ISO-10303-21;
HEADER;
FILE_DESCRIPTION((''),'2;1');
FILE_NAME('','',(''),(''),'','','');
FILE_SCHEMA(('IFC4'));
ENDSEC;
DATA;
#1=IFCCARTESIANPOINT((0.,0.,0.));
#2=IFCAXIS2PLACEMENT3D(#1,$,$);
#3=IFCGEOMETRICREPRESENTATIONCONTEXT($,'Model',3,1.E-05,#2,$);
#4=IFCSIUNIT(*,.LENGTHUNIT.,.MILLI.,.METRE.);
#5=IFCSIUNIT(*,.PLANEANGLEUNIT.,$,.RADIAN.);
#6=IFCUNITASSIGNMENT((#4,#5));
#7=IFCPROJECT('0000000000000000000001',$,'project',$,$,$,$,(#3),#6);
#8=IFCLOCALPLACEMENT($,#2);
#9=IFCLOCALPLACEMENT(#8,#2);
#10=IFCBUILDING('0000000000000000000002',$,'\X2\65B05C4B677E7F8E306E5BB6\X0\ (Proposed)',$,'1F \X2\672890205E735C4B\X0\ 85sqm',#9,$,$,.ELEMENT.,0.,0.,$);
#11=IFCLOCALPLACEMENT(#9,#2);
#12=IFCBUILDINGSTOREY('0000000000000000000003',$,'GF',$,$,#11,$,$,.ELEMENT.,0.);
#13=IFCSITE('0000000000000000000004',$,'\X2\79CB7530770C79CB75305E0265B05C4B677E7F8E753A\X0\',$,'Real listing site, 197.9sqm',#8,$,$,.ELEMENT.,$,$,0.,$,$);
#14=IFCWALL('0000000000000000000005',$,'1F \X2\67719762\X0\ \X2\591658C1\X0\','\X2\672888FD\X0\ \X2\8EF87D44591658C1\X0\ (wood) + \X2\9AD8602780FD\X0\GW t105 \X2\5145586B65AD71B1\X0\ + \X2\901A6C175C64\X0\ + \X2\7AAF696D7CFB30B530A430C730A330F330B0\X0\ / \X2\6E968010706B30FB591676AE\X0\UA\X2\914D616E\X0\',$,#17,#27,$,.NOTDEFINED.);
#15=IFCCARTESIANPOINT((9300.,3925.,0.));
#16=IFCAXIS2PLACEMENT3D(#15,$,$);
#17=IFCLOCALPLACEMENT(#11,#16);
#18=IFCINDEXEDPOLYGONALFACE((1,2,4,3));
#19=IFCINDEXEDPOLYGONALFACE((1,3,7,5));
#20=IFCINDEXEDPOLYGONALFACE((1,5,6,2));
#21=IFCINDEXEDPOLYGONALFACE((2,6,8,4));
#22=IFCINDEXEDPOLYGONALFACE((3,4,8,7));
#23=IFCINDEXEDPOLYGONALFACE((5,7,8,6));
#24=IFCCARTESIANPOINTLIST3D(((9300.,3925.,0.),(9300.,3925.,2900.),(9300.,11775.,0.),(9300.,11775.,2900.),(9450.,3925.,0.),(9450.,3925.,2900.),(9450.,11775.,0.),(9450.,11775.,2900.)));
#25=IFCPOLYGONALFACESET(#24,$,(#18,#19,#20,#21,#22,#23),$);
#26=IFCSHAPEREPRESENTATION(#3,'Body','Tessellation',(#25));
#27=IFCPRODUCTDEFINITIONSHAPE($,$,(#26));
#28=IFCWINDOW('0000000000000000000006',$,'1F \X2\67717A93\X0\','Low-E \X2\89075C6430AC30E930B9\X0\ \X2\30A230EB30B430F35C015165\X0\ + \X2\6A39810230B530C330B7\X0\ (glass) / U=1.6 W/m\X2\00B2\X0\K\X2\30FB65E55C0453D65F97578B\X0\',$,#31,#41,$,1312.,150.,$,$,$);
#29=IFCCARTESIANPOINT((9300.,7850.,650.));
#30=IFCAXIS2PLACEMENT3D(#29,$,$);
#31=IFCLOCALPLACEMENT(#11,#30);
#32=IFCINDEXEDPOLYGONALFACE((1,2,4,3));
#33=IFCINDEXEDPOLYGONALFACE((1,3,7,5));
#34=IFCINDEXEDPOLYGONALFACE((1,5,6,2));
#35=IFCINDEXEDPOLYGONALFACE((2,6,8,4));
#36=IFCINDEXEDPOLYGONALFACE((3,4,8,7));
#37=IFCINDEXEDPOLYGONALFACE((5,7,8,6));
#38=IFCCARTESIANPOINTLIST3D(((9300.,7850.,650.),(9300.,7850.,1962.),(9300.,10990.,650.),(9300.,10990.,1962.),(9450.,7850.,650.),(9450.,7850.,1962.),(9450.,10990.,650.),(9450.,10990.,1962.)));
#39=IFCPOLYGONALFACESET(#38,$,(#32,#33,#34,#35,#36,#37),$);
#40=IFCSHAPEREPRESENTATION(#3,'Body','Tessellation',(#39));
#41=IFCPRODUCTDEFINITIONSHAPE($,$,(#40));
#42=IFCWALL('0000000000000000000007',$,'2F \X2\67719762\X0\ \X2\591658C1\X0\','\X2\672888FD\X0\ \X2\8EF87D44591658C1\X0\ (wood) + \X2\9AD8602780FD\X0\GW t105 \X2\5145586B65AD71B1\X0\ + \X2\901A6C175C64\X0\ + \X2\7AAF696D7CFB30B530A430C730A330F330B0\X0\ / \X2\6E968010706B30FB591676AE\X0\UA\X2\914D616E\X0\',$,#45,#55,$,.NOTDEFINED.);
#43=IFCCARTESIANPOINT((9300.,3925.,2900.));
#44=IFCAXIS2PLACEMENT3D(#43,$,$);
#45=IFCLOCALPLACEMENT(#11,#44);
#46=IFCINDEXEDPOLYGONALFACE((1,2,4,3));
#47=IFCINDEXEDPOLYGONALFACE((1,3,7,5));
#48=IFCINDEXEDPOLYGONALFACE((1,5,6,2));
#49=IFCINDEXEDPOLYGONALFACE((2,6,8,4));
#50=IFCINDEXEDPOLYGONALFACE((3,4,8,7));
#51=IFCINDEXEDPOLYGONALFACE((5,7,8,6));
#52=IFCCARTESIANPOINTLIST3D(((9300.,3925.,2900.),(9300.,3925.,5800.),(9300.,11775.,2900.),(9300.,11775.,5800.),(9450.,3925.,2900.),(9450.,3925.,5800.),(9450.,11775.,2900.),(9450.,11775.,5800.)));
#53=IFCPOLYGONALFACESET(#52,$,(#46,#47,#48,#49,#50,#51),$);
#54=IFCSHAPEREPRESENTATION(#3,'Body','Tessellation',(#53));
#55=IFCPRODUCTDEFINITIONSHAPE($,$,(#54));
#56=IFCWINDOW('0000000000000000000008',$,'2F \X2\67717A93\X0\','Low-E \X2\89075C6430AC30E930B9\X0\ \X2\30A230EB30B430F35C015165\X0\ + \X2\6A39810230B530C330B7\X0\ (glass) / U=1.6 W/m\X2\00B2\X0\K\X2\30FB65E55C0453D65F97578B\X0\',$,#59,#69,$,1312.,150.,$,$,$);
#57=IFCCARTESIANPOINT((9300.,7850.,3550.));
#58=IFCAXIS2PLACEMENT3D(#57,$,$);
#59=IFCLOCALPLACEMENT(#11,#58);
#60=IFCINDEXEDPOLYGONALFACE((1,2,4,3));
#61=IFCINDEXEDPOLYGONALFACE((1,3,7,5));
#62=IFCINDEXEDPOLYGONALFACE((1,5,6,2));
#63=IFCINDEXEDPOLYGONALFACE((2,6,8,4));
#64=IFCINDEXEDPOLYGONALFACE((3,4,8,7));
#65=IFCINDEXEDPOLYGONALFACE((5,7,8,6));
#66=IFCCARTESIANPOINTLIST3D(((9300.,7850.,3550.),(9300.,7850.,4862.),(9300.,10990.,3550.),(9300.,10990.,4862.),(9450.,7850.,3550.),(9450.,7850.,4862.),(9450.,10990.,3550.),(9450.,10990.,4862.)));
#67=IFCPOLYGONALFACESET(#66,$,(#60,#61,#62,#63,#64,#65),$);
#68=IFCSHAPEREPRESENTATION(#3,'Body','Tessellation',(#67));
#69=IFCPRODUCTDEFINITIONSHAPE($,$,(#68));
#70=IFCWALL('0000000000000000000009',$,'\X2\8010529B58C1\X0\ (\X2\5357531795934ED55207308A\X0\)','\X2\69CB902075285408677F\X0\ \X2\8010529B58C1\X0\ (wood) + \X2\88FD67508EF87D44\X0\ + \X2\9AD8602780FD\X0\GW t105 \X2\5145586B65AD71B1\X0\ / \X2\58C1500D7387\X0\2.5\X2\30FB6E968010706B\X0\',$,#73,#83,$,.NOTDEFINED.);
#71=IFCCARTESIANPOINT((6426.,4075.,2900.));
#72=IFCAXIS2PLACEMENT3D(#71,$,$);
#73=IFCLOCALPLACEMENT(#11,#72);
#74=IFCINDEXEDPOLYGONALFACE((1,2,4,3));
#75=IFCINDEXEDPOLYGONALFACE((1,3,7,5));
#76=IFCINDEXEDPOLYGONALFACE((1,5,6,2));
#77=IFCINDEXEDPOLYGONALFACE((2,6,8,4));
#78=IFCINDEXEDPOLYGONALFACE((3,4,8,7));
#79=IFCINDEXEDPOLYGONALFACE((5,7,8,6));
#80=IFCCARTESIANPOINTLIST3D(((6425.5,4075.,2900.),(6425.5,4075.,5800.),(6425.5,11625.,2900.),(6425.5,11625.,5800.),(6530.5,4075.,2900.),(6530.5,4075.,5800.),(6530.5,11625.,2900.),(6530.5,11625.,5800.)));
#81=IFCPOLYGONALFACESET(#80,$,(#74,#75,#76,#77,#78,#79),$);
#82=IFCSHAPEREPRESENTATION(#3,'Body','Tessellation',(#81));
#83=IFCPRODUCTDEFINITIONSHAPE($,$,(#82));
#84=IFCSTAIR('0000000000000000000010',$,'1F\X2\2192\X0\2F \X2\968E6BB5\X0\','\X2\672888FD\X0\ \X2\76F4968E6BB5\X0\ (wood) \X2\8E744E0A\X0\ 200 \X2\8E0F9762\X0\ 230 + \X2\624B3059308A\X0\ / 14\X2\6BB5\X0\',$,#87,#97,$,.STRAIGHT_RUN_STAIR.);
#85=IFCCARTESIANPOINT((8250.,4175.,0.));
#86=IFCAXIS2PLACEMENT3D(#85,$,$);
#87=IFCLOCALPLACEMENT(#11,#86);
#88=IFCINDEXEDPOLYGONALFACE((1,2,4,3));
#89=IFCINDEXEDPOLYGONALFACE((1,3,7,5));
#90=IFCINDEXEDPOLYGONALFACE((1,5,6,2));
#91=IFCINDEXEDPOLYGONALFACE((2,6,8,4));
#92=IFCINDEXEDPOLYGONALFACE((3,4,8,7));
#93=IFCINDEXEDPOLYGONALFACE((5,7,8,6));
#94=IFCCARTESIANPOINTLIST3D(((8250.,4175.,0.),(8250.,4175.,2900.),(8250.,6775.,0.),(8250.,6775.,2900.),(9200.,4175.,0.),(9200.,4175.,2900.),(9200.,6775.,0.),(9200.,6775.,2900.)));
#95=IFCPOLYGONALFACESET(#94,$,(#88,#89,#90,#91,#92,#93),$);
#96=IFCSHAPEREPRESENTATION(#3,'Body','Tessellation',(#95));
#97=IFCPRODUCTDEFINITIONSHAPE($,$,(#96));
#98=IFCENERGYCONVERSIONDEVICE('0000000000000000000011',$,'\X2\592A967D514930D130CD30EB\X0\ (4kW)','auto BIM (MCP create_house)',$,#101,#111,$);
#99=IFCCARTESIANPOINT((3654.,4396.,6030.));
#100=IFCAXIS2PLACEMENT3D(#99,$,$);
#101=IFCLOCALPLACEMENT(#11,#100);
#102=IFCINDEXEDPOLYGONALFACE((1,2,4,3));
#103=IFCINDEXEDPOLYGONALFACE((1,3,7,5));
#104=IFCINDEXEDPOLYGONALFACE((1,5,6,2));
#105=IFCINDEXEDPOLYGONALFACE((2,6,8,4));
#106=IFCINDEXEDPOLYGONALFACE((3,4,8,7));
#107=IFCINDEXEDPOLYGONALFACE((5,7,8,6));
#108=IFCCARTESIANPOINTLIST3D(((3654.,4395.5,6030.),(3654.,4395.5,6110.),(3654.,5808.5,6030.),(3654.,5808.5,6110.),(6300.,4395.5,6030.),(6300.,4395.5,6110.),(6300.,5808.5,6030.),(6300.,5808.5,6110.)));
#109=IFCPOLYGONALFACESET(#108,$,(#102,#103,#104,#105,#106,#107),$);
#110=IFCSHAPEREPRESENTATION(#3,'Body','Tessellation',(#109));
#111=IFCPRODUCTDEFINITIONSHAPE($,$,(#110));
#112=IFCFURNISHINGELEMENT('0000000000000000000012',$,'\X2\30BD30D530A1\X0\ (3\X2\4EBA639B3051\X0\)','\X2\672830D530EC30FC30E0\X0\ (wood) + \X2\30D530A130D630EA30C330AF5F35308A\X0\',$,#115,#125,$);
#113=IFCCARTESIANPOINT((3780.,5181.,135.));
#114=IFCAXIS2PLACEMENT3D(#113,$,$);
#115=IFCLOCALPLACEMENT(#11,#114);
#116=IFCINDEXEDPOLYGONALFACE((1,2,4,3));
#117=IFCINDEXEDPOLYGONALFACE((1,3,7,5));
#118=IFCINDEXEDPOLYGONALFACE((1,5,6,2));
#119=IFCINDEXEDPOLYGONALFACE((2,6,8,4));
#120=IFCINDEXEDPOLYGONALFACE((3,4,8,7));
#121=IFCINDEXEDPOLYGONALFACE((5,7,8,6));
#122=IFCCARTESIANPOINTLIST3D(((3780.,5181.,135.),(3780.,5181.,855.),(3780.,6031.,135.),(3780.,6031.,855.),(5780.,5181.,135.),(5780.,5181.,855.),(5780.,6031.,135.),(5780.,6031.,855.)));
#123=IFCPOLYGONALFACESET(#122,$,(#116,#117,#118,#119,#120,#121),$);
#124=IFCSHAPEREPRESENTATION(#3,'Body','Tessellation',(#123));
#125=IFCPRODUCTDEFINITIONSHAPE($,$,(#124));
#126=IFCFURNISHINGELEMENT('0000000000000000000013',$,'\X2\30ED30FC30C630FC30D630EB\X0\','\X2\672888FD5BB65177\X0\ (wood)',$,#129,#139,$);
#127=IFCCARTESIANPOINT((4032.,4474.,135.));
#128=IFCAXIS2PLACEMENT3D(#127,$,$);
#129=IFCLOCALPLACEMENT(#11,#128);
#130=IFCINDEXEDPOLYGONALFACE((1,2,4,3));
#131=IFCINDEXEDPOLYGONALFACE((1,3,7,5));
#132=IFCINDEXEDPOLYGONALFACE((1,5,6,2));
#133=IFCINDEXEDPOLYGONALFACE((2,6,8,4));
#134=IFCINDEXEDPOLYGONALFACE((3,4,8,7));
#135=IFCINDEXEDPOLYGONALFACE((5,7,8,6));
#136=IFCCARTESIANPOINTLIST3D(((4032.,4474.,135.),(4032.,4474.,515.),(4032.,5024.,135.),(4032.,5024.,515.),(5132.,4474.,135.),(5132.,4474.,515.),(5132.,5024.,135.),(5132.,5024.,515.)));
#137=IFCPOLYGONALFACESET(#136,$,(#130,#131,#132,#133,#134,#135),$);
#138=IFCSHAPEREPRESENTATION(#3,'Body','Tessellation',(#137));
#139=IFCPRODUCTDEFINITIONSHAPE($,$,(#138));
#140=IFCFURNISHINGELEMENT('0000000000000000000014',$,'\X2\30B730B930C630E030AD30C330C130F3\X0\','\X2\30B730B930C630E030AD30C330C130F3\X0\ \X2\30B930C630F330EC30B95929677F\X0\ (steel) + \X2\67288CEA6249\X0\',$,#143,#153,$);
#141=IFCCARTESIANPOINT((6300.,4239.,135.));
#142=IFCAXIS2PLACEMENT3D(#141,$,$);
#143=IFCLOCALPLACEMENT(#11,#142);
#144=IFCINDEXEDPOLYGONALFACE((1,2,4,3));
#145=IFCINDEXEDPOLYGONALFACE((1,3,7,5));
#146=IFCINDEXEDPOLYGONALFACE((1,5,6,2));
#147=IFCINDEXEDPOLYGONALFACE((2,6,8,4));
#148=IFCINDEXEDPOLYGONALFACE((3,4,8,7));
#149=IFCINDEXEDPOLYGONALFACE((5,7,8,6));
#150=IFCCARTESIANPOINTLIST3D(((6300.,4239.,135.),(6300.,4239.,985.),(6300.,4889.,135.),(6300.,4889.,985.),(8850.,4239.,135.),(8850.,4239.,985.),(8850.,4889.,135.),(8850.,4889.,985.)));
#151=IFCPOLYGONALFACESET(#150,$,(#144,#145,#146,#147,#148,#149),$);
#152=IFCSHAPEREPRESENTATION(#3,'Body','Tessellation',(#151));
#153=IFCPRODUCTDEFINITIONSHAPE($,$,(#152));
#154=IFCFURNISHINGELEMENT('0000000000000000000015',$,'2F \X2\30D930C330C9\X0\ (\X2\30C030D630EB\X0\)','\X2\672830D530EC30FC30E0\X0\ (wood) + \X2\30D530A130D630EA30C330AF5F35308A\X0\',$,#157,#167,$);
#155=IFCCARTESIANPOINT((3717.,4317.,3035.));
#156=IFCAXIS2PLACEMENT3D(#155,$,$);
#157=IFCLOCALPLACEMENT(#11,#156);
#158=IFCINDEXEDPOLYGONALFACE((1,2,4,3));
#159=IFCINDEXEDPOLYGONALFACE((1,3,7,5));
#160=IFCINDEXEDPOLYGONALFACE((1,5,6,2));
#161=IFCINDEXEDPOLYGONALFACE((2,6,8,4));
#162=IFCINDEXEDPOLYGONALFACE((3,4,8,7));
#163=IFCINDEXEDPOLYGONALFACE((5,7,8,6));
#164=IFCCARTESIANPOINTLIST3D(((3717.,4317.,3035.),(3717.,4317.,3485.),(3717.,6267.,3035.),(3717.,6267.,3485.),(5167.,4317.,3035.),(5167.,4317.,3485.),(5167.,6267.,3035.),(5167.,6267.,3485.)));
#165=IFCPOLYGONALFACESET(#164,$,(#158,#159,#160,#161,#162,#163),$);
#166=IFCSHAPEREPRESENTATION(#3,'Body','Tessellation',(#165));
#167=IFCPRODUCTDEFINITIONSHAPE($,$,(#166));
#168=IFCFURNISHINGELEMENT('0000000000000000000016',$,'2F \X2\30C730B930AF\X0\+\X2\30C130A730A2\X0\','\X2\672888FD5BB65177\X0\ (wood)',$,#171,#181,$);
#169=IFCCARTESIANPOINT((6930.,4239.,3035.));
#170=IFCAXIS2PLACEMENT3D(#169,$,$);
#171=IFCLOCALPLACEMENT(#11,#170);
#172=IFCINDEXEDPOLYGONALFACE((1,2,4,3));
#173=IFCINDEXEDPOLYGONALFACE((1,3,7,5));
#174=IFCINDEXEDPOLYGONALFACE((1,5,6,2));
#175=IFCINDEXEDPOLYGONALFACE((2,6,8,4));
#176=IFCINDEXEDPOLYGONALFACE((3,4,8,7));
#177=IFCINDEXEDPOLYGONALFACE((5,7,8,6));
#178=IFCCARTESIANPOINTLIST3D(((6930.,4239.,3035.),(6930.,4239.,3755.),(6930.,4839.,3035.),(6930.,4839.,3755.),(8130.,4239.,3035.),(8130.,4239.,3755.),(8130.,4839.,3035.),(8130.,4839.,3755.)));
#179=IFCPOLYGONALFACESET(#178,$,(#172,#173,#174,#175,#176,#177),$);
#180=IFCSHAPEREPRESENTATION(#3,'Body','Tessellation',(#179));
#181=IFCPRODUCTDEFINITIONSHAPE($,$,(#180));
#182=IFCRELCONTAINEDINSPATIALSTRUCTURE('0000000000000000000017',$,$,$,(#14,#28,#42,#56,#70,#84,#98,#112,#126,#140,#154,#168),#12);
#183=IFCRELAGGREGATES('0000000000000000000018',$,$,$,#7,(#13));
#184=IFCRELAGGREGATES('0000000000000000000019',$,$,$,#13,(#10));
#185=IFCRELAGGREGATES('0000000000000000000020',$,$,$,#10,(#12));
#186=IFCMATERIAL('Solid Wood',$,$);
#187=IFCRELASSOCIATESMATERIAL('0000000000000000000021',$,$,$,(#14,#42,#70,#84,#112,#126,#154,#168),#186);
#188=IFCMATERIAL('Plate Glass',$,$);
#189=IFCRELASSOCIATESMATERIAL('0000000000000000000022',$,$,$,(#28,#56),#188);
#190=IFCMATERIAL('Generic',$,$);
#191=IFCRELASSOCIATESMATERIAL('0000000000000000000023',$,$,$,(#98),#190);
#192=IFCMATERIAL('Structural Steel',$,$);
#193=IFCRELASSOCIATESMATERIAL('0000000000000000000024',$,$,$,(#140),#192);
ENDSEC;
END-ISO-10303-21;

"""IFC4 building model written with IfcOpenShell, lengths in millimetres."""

from ifc_helpers import new_model, si_unit, frame, frame_2d, origin, place, context, project, spatial, rectangle, extrude, material, element, fill, save


model = new_model("IFC4")

# Units and contexts
model_context = context("Model", 3, precision=1e-05, world=origin())
ifc_project = project(units=[si_unit("LENGTHUNIT", "METRE", prefix="MILLI"), si_unit("PLANEANGLEUNIT", "RADIAN")], contexts=[model_context])

# Site, building, storey
site_placement = place(None, origin())
site = spatial("IfcSite", under=ifc_project, at=site_placement, Name="秋田県秋田市新屋松美町", ObjectType="Real listing site, 197.9sqm", CompositionType="ELEMENT", RefElevation=0.0)
building_placement = place(site_placement, origin())
building = spatial("IfcBuilding", under=site, at=building_placement, Name="新屋松美の家 (Proposed)", ObjectType="1F 木造平屋 85sqm", CompositionType="ELEMENT", ElevationOfRefHeight=0.0, ElevationOfTerrain=0.0)
storey_placement = place(building_placement, origin())
storey = spatial("IfcBuildingStorey", under=building, at=storey_placement, Name="GF", CompositionType="ELEMENT", Elevation=0.0)

# Wall, opening, window
ifc_material_1 = material(Name="Solid Wood")
wall_1_placement = place(storey_placement, frame((9300.0, 3925.0, 0.0)))
wall_1 = element("IfcWall", 1, at=wall_1_placement, inside=storey, material=ifc_material_1, Name="1F 東面 外壁", Description="木製 軸組外壁 (wood) + 高性能GW t105 充填断熱 + 通気層 + 窯業系サイディング / 準耐火・外皮UA配慮", PredefinedType="NOTDEFINED", context=model_context, shape_type="SweptSolid", body=[
    extrude(rectangle(XDim=150.0, YDim=7850.0, at=frame_2d((75.0, 3925.0))), frame((9300.0, 3925.0, 0.0)), (0.0, 0.0, 1.0), 2900.0),
])
opening_1_placement = place(storey_placement, frame((9300.0, 7850.0, 650.0)))
opening_1 = element("IfcOpeningElement", 2, at=opening_1_placement, cuts=wall_1, PredefinedType="NOTDEFINED", context=model_context, shape_type="SweptSolid", body=[
    extrude(rectangle(XDim=150.0, YDim=3140.0, at=frame_2d((75.0, 1570.0))), frame((9300.0, 7850.0, 650.0)), (0.0, 0.0, 1.0), 1312.0),
])
ifc_material_2 = material(Name="Plate Glass")
window_1_placement = place(storey_placement, frame((9300.0, 7850.0, 650.0)))
window_1 = element("IfcWindow", 3, at=window_1_placement, inside=storey, material=ifc_material_2, Name="1F 東窓", Description="Low-E 複層ガラス アルゴン封入 + 樹脂サッシ (glass) / U=1.6 W/m²K・日射取得型", OverallHeight=1312.0, OverallWidth=150.0, context=model_context, shape_type="SweptSolid", body=[
    extrude(rectangle(XDim=150.0, YDim=3140.0, at=frame_2d((75.0, 1570.0))), frame((9300.0, 7850.0, 650.0)), (0.0, 0.0, 1.0), 1312.0),
])
fill(opening_1, window_1)

# Wall, opening, window
wall_2_placement = place(storey_placement, frame((9300.0, 3925.0, 2900.0)))
wall_2 = element("IfcWall", 4, at=wall_2_placement, inside=storey, material=ifc_material_1, Name="2F 東面 外壁", Description="木製 軸組外壁 (wood) + 高性能GW t105 充填断熱 + 通気層 + 窯業系サイディング / 準耐火・外皮UA配慮", PredefinedType="NOTDEFINED", context=model_context, shape_type="SweptSolid", body=[
    extrude(rectangle(XDim=150.0, YDim=7850.0, at=frame_2d((75.0, 3925.0))), frame((9300.0, 3925.0, 2900.0)), (0.0, 0.0, 1.0), 2900.0),
])
opening_2_placement = place(storey_placement, frame((9300.0, 7850.0, 3550.0)))
opening_2 = element("IfcOpeningElement", 5, at=opening_2_placement, cuts=wall_2, PredefinedType="NOTDEFINED", context=model_context, shape_type="SweptSolid", body=[
    extrude(rectangle(XDim=150.0, YDim=3140.0, at=frame_2d((75.0, 1570.0))), frame((9300.0, 7850.0, 3550.0)), (0.0, 0.0, 1.0), 1312.0),
])
window_2_placement = place(storey_placement, frame((9300.0, 7850.0, 3550.0)))
window_2 = element("IfcWindow", 6, at=window_2_placement, inside=storey, material=ifc_material_2, Name="2F 東窓", Description="Low-E 複層ガラス アルゴン封入 + 樹脂サッシ (glass) / U=1.6 W/m²K・日射取得型", OverallHeight=1312.0, OverallWidth=150.0, context=model_context, shape_type="SweptSolid", body=[
    extrude(rectangle(XDim=150.0, YDim=3140.0, at=frame_2d((75.0, 1570.0))), frame((9300.0, 7850.0, 3550.0)), (0.0, 0.0, 1.0), 1312.0),
])
fill(opening_2, window_2)

# Wall
wall_3_placement = place(storey_placement, frame((6426.0, 4075.0, 2900.0)))
element("IfcWall", 7, at=wall_3_placement, inside=storey, material=ifc_material_1, Name="耐力壁 (南北間仕切り)", Description="構造用合板 耐力壁 (wood) + 製材軸組 + 高性能GW t105 充填断熱 / 壁倍率2.5・準耐火", PredefinedType="NOTDEFINED", context=model_context, shape_type="SweptSolid", body=[
    extrude(rectangle(XDim=105.0, YDim=7550.0, at=frame_2d((52.0, 3775.0))), frame((6426.0, 4075.0, 2900.0)), (0.0, 0.0, 1.0), 2900.0),
])

# Stair
stair_placement = place(storey_placement, frame((8250.0, 4175.0, 0.0)))
element("IfcStair", 8, at=stair_placement, inside=storey, material=ifc_material_1, Name="1F→2F 階段", Description="木製 直階段 (wood) 蹴上 200 踏面 230 + 手すり / 14段", PredefinedType="STRAIGHT_RUN_STAIR", context=model_context, shape_type="SweptSolid", body=[
    extrude(rectangle(XDim=950.0, YDim=2600.0, at=frame_2d((475.0, 1300.0))), frame((8250.0, 4175.0, 0.0)), (0.0, 0.0, 1.0), 2900.0),
])

# Energy conversion device
ifc_material_3 = material(Name="Generic")
energy_conversion_device_placement = place(storey_placement, frame((3654.0, 4396.0, 6030.0)))
element("IfcEnergyConversionDevice", 9, at=energy_conversion_device_placement, inside=storey, material=ifc_material_3, Name="太陽光パネル (4kW)", Description="auto BIM (MCP create_house)", context=model_context, shape_type="SweptSolid", body=[
    extrude(rectangle(XDim=2646.0, YDim=1413.0, at=frame_2d((1323.0, 706.0))), frame((3654.0, 4396.0, 6030.0)), (0.0, 0.0, 1.0), 80.0),
])

# Furnishing elements
furnishing_1_placement = place(storey_placement, frame((3780.0, 5181.0, 135.0)))
element("IfcFurnishingElement", 10, at=furnishing_1_placement, inside=storey, material=ifc_material_1, Name="ソファ (3人掛け)", Description="木フレーム (wood) + ファブリック張り", context=model_context, shape_type="SweptSolid", body=[
    extrude(rectangle(XDim=2000.0, YDim=850.0, at=frame_2d((1000.0, 425.0))), frame((3780.0, 5181.0, 135.0)), (0.0, 0.0, 1.0), 720.0),
])
furnishing_2_placement = place(storey_placement, frame((4032.0, 4474.0, 135.0)))
element("IfcFurnishingElement", 11, at=furnishing_2_placement, inside=storey, material=ifc_material_1, Name="ローテーブル", Description="木製家具 (wood)", context=model_context, shape_type="SweptSolid", body=[
    extrude(rectangle(XDim=1100.0, YDim=550.0, at=frame_2d((550.0, 275.0))), frame((4032.0, 4474.0, 135.0)), (0.0, 0.0, 1.0), 380.0),
])
ifc_material_4 = material(Name="Structural Steel")
furnishing_3_placement = place(storey_placement, frame((6300.0, 4239.0, 135.0)))
element("IfcFurnishingElement", 12, at=furnishing_3_placement, inside=storey, material=ifc_material_4, Name="システムキッチン", Description="システムキッチン ステンレス天板 (steel) + 木質扉", context=model_context, shape_type="SweptSolid", body=[
    extrude(rectangle(XDim=2550.0, YDim=650.0, at=frame_2d((1275.0, 325.0))), frame((6300.0, 4239.0, 135.0)), (0.0, 0.0, 1.0), 850.0),
])
furnishing_4_placement = place(storey_placement, frame((3717.0, 4317.0, 3035.0)))
element("IfcFurnishingElement", 13, at=furnishing_4_placement, inside=storey, material=ifc_material_1, Name="2F ベッド (ダブル)", Description="木フレーム (wood) + ファブリック張り", context=model_context, shape_type="SweptSolid", body=[
    extrude(rectangle(XDim=1450.0, YDim=1950.0, at=frame_2d((725.0, 975.0))), frame((3717.0, 4317.0, 3035.0)), (0.0, 0.0, 1.0), 450.0),
])
furnishing_5_placement = place(storey_placement, frame((6930.0, 4239.0, 3035.0)))
element("IfcFurnishingElement", 14, at=furnishing_5_placement, inside=storey, material=ifc_material_1, Name="2F デスク+チェア", Description="木製家具 (wood)", context=model_context, shape_type="SweptSolid", body=[
    extrude(rectangle(XDim=1200.0, YDim=600.0, at=frame_2d((600.0, 300.0))), frame((6930.0, 4239.0, 3035.0)), (0.0, 0.0, 1.0), 720.0),
])

save(model, "model.ifc")
